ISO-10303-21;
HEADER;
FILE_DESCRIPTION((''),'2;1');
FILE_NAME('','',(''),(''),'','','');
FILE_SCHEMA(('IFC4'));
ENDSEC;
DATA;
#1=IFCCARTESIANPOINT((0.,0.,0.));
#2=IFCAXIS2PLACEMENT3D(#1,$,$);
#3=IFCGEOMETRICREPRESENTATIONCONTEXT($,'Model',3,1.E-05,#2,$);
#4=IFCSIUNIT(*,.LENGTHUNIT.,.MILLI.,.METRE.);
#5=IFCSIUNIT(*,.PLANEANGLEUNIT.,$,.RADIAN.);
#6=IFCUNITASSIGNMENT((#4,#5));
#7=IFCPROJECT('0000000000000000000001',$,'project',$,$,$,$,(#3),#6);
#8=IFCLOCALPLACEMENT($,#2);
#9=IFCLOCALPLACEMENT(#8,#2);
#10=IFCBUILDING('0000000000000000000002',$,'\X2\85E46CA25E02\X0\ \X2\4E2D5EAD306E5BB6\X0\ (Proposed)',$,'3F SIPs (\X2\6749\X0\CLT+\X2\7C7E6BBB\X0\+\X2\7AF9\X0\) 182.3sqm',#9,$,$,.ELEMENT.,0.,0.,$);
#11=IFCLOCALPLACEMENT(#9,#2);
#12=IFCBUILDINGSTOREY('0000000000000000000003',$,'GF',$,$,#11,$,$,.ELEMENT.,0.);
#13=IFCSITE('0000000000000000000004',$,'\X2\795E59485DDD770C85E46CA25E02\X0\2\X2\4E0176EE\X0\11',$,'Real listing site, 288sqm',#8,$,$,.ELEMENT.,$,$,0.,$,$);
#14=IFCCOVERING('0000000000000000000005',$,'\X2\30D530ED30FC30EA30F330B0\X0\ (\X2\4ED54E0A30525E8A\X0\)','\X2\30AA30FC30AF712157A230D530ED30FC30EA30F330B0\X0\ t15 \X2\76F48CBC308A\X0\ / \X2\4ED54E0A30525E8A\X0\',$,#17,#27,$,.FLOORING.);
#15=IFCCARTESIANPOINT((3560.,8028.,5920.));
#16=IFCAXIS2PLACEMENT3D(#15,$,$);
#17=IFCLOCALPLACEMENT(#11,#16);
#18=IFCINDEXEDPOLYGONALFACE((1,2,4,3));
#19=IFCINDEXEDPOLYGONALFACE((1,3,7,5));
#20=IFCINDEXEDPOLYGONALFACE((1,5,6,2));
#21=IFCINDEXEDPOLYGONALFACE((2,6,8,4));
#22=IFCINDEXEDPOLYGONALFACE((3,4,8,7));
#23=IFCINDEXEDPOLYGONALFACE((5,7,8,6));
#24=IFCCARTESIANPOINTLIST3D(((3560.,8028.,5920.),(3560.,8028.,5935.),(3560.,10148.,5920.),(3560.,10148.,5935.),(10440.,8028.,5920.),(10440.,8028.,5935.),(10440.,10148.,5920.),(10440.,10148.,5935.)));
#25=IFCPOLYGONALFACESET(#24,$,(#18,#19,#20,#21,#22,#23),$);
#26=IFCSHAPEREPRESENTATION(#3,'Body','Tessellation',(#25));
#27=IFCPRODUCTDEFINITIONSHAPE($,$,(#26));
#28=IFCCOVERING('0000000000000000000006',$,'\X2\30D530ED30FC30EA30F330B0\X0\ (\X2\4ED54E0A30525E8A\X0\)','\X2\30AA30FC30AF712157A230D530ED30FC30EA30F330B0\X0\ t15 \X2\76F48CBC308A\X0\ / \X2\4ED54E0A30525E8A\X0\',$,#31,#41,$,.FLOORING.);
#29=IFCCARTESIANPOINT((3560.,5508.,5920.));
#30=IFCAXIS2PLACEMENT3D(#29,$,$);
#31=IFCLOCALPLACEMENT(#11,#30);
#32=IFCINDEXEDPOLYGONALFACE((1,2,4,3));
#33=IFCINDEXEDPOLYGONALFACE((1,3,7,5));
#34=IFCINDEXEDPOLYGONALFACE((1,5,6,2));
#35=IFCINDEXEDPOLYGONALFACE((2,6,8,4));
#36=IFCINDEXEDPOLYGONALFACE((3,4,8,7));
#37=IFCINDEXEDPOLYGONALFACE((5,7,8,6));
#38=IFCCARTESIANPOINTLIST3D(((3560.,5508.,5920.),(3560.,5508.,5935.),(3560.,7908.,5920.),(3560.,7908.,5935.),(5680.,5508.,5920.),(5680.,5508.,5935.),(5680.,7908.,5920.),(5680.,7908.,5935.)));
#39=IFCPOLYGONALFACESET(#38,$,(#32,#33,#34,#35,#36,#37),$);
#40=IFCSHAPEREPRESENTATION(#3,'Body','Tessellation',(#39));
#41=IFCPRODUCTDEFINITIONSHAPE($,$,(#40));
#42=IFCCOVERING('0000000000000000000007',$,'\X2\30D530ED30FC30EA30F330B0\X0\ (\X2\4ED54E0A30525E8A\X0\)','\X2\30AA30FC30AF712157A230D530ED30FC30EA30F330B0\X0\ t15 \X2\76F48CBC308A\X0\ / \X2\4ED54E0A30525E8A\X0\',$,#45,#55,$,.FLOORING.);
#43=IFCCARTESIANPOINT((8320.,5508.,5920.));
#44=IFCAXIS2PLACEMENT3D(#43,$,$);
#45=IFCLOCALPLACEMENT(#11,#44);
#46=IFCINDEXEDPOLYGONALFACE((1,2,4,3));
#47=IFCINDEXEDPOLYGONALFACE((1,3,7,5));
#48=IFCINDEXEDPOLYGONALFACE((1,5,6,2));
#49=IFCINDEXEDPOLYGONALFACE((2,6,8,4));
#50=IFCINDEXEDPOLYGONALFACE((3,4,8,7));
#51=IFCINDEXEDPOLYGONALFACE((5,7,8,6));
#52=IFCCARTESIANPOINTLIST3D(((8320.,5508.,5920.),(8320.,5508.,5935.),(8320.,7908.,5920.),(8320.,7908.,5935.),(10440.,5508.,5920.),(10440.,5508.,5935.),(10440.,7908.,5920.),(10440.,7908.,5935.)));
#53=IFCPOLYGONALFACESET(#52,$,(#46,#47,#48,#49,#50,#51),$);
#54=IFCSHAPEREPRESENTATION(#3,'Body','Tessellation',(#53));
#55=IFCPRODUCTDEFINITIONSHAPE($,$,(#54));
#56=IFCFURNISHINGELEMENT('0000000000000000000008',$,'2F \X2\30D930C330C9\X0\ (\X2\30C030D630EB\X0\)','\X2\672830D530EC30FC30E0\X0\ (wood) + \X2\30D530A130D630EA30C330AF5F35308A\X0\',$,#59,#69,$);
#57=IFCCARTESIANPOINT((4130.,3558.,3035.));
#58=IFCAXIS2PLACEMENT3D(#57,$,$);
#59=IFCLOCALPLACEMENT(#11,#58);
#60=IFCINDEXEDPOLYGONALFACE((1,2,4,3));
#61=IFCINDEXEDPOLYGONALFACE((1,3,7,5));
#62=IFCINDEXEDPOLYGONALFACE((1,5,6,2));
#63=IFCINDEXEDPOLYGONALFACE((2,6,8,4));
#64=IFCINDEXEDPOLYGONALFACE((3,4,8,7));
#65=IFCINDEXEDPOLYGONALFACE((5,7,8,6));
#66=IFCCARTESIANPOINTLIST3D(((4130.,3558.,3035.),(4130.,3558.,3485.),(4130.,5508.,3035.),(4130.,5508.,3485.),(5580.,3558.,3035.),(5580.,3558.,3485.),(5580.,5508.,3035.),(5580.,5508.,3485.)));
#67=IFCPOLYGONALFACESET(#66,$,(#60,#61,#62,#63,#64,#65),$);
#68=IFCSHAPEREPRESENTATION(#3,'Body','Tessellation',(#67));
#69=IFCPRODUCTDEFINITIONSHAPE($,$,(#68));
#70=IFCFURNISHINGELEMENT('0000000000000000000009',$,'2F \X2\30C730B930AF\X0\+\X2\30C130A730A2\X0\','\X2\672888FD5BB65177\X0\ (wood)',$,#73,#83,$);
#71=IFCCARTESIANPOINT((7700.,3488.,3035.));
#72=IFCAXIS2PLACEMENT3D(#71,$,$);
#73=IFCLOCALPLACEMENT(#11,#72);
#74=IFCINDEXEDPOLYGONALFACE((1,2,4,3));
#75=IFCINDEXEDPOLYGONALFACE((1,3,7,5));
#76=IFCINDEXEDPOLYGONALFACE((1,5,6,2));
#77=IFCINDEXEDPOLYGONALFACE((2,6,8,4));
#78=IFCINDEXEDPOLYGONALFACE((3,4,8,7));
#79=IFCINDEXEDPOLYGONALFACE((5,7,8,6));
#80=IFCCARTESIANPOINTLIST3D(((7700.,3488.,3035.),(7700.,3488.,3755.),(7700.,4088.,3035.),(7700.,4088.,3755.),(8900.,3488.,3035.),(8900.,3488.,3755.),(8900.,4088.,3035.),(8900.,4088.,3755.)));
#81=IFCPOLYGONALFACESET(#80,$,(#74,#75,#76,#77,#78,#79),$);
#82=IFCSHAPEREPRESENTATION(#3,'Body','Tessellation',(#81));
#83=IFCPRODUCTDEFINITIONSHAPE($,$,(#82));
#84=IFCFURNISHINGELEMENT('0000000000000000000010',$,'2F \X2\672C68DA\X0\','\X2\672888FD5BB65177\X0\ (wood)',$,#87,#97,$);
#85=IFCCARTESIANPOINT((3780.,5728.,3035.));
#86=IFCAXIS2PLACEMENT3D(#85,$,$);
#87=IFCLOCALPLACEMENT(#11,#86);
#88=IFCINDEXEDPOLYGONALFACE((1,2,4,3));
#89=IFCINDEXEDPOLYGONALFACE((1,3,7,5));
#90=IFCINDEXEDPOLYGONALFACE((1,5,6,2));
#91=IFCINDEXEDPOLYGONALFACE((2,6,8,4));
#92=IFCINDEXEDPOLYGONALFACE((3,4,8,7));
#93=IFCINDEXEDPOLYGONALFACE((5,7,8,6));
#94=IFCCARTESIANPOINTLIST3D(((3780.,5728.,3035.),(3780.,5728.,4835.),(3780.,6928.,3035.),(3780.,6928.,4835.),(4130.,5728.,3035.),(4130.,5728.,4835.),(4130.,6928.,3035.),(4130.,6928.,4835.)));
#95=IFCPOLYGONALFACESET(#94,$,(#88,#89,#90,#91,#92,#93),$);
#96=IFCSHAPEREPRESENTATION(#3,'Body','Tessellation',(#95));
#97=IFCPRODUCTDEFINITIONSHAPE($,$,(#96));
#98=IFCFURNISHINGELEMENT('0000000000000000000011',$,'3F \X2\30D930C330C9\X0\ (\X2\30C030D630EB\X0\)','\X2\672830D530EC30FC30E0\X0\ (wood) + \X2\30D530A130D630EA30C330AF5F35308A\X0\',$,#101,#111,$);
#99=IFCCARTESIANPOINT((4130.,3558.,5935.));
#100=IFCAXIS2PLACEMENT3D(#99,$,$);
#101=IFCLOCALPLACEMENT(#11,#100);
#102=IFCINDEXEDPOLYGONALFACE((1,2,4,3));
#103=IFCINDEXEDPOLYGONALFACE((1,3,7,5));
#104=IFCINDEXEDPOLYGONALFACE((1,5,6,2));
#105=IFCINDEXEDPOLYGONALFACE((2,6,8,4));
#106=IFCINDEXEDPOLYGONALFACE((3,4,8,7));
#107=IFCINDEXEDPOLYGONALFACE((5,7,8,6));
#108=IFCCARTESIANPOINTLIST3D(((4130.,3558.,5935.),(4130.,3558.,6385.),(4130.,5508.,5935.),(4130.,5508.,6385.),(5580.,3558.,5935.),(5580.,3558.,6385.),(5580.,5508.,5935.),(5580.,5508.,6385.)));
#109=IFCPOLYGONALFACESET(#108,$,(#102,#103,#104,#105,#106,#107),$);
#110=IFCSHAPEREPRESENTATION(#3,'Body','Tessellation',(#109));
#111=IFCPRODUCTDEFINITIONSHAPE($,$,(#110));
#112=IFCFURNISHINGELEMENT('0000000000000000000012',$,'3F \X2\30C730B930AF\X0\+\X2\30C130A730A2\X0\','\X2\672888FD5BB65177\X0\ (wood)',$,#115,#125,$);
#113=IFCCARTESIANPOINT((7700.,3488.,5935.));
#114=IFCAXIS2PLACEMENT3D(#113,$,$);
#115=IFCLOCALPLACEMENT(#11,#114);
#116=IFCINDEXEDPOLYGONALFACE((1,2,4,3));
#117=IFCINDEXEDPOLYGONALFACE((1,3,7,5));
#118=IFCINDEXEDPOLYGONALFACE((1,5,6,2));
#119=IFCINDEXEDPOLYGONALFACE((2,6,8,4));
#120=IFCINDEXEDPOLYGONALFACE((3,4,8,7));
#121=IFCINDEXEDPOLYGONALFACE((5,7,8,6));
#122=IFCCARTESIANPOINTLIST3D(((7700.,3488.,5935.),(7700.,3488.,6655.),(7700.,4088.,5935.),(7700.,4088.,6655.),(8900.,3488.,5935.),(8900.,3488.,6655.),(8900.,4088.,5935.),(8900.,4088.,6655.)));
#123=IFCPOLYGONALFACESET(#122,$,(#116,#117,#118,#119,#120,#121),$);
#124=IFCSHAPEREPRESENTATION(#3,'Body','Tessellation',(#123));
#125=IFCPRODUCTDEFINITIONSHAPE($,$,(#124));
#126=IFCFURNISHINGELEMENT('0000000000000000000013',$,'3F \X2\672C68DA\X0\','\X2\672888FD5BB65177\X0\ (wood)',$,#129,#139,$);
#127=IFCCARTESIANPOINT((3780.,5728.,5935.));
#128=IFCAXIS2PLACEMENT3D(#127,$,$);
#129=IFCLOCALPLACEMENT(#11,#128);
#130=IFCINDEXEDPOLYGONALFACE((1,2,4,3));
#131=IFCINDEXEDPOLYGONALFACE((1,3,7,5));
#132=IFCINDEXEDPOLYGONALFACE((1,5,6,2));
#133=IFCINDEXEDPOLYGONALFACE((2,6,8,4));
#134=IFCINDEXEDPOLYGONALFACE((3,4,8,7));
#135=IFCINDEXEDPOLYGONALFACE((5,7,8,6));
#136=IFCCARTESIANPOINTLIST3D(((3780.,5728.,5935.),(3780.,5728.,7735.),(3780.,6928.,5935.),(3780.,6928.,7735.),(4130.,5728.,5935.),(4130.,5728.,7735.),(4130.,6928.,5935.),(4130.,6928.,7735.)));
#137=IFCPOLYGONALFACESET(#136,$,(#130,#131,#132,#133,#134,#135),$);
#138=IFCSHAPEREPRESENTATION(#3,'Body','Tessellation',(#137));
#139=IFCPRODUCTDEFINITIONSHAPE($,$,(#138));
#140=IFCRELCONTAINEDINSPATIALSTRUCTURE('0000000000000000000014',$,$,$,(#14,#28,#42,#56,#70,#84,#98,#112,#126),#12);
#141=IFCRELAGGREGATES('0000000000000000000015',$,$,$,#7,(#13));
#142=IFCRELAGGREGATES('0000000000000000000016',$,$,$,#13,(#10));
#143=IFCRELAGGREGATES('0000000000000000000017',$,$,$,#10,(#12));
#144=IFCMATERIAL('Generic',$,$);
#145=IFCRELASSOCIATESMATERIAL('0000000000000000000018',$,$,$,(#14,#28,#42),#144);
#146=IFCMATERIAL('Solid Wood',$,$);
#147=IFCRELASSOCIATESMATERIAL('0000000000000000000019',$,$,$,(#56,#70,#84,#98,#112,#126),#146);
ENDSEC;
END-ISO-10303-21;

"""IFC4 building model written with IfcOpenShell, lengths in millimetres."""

from ifc_helpers import new_model, si_unit, frame, frame_2d, origin, place, context, project, spatial, rectangle, extrude, material, element, save


model = new_model("IFC4")

# Units and contexts
model_context = context("Model", 3, precision=1e-05, world=origin())
ifc_project = project(units=[si_unit("LENGTHUNIT", "METRE", prefix="MILLI"), si_unit("PLANEANGLEUNIT", "RADIAN")], contexts=[model_context])

# Site, building, storey
site_placement = place(None, origin())
site = spatial("IfcSite", under=ifc_project, at=site_placement, Name="神奈川県藤沢市2丁目11", ObjectType="Real listing site, 288sqm", CompositionType="ELEMENT", RefElevation=0.0)
building_placement = place(site_placement, origin())
building = spatial("IfcBuilding", under=site, at=building_placement, Name="藤沢市 中庭の家 (Proposed)", ObjectType="3F SIPs (杉CLT+籾殻+竹) 182.3sqm", CompositionType="ELEMENT", ElevationOfRefHeight=0.0, ElevationOfTerrain=0.0)
storey_placement = place(building_placement, origin())
storey = spatial("IfcBuildingStorey", under=building, at=storey_placement, Name="GF", CompositionType="ELEMENT", Elevation=0.0)

# Shared definitions
ifc_material_1 = material(Name="Solid Wood")

# Shared definitions
ifc_material_2 = material(Name="Generic")

# Coverings
covering_1_placement = place(storey_placement, frame((3560.0, 8028.0, 5920.0)))
element("IfcCovering", 1, at=covering_1_placement, inside=storey, material=ifc_material_2, Name="フローリング (仕上げ床)", Description="オーク無垢フローリング t15 直貼り / 仕上げ床", PredefinedType="FLOORING", context=model_context, shape_type="SweptSolid", body=[
    extrude(rectangle(XDim=6880.0, YDim=2120.0, at=frame_2d((3440.0, 1060.0))), frame((3560.0, 8028.0, 5920.0)), (0.0, 0.0, 1.0), 15.0),
])
covering_2_placement = place(storey_placement, frame((3560.0, 5508.0, 5920.0)))
element("IfcCovering", 2, at=covering_2_placement, inside=storey, material=ifc_material_2, Name="フローリング (仕上げ床)", Description="オーク無垢フローリング t15 直貼り / 仕上げ床", PredefinedType="FLOORING", context=model_context, shape_type="SweptSolid", body=[
    extrude(rectangle(XDim=2120.0, YDim=2400.0, at=frame_2d((1060.0, 1200.0))), frame((3560.0, 5508.0, 5920.0)), (0.0, 0.0, 1.0), 15.0),
])
covering_3_placement = place(storey_placement, frame((8320.0, 5508.0, 5920.0)))
element("IfcCovering", 3, at=covering_3_placement, inside=storey, material=ifc_material_2, Name="フローリング (仕上げ床)", Description="オーク無垢フローリング t15 直貼り / 仕上げ床", PredefinedType="FLOORING", context=model_context, shape_type="SweptSolid", body=[
    extrude(rectangle(XDim=2120.0, YDim=2400.0, at=frame_2d((1060.0, 1200.0))), frame((8320.0, 5508.0, 5920.0)), (0.0, 0.0, 1.0), 15.0),
])

# Furnishing elements
furnishing_1_placement = place(storey_placement, frame((4130.0, 3558.0, 3035.0)))
element("IfcFurnishingElement", 4, at=furnishing_1_placement, inside=storey, material=ifc_material_1, Name="2F ベッド (ダブル)", Description="木フレーム (wood) + ファブリック張り", context=model_context, shape_type="SweptSolid", body=[
    extrude(rectangle(XDim=1450.0, YDim=1950.0, at=frame_2d((725.0, 975.0))), frame((4130.0, 3558.0, 3035.0)), (0.0, 0.0, 1.0), 450.0),
])
furnishing_2_placement = place(storey_placement, frame((7700.0, 3488.0, 3035.0)))
element("IfcFurnishingElement", 5, at=furnishing_2_placement, inside=storey, material=ifc_material_1, Name="2F デスク+チェア", Description="木製家具 (wood)", context=model_context, shape_type="SweptSolid", body=[
    extrude(rectangle(XDim=1200.0, YDim=600.0, at=frame_2d((600.0, 300.0))), frame((7700.0, 3488.0, 3035.0)), (0.0, 0.0, 1.0), 720.0),
])
furnishing_3_placement = place(storey_placement, frame((3780.0, 5728.0, 3035.0)))
element("IfcFurnishingElement", 6, at=furnishing_3_placement, inside=storey, material=ifc_material_1, Name="2F 本棚", Description="木製家具 (wood)", context=model_context, shape_type="SweptSolid", body=[
    extrude(rectangle(XDim=350.0, YDim=1200.0, at=frame_2d((175.0, 600.0))), frame((3780.0, 5728.0, 3035.0)), (0.0, 0.0, 1.0), 1800.0),
])
furnishing_4_placement = place(storey_placement, frame((4130.0, 3558.0, 5935.0)))
element("IfcFurnishingElement", 7, at=furnishing_4_placement, inside=storey, material=ifc_material_1, Name="3F ベッド (ダブル)", Description="木フレーム (wood) + ファブリック張り", context=model_context, shape_type="SweptSolid", body=[
    extrude(rectangle(XDim=1450.0, YDim=1950.0, at=frame_2d((725.0, 975.0))), frame((4130.0, 3558.0, 5935.0)), (0.0, 0.0, 1.0), 450.0),
])
furnishing_5_placement = place(storey_placement, frame((7700.0, 3488.0, 5935.0)))
element("IfcFurnishingElement", 8, at=furnishing_5_placement, inside=storey, material=ifc_material_1, Name="3F デスク+チェア", Description="木製家具 (wood)", context=model_context, shape_type="SweptSolid", body=[
    extrude(rectangle(XDim=1200.0, YDim=600.0, at=frame_2d((600.0, 300.0))), frame((7700.0, 3488.0, 5935.0)), (0.0, 0.0, 1.0), 720.0),
])
furnishing_6_placement = place(storey_placement, frame((3780.0, 5728.0, 5935.0)))
element("IfcFurnishingElement", 9, at=furnishing_6_placement, inside=storey, material=ifc_material_1, Name="3F 本棚", Description="木製家具 (wood)", context=model_context, shape_type="SweptSolid", body=[
    extrude(rectangle(XDim=350.0, YDim=1200.0, at=frame_2d((175.0, 600.0))), frame((3780.0, 5728.0, 5935.0)), (0.0, 0.0, 1.0), 1800.0),
])

save(model, "model.ifc")
